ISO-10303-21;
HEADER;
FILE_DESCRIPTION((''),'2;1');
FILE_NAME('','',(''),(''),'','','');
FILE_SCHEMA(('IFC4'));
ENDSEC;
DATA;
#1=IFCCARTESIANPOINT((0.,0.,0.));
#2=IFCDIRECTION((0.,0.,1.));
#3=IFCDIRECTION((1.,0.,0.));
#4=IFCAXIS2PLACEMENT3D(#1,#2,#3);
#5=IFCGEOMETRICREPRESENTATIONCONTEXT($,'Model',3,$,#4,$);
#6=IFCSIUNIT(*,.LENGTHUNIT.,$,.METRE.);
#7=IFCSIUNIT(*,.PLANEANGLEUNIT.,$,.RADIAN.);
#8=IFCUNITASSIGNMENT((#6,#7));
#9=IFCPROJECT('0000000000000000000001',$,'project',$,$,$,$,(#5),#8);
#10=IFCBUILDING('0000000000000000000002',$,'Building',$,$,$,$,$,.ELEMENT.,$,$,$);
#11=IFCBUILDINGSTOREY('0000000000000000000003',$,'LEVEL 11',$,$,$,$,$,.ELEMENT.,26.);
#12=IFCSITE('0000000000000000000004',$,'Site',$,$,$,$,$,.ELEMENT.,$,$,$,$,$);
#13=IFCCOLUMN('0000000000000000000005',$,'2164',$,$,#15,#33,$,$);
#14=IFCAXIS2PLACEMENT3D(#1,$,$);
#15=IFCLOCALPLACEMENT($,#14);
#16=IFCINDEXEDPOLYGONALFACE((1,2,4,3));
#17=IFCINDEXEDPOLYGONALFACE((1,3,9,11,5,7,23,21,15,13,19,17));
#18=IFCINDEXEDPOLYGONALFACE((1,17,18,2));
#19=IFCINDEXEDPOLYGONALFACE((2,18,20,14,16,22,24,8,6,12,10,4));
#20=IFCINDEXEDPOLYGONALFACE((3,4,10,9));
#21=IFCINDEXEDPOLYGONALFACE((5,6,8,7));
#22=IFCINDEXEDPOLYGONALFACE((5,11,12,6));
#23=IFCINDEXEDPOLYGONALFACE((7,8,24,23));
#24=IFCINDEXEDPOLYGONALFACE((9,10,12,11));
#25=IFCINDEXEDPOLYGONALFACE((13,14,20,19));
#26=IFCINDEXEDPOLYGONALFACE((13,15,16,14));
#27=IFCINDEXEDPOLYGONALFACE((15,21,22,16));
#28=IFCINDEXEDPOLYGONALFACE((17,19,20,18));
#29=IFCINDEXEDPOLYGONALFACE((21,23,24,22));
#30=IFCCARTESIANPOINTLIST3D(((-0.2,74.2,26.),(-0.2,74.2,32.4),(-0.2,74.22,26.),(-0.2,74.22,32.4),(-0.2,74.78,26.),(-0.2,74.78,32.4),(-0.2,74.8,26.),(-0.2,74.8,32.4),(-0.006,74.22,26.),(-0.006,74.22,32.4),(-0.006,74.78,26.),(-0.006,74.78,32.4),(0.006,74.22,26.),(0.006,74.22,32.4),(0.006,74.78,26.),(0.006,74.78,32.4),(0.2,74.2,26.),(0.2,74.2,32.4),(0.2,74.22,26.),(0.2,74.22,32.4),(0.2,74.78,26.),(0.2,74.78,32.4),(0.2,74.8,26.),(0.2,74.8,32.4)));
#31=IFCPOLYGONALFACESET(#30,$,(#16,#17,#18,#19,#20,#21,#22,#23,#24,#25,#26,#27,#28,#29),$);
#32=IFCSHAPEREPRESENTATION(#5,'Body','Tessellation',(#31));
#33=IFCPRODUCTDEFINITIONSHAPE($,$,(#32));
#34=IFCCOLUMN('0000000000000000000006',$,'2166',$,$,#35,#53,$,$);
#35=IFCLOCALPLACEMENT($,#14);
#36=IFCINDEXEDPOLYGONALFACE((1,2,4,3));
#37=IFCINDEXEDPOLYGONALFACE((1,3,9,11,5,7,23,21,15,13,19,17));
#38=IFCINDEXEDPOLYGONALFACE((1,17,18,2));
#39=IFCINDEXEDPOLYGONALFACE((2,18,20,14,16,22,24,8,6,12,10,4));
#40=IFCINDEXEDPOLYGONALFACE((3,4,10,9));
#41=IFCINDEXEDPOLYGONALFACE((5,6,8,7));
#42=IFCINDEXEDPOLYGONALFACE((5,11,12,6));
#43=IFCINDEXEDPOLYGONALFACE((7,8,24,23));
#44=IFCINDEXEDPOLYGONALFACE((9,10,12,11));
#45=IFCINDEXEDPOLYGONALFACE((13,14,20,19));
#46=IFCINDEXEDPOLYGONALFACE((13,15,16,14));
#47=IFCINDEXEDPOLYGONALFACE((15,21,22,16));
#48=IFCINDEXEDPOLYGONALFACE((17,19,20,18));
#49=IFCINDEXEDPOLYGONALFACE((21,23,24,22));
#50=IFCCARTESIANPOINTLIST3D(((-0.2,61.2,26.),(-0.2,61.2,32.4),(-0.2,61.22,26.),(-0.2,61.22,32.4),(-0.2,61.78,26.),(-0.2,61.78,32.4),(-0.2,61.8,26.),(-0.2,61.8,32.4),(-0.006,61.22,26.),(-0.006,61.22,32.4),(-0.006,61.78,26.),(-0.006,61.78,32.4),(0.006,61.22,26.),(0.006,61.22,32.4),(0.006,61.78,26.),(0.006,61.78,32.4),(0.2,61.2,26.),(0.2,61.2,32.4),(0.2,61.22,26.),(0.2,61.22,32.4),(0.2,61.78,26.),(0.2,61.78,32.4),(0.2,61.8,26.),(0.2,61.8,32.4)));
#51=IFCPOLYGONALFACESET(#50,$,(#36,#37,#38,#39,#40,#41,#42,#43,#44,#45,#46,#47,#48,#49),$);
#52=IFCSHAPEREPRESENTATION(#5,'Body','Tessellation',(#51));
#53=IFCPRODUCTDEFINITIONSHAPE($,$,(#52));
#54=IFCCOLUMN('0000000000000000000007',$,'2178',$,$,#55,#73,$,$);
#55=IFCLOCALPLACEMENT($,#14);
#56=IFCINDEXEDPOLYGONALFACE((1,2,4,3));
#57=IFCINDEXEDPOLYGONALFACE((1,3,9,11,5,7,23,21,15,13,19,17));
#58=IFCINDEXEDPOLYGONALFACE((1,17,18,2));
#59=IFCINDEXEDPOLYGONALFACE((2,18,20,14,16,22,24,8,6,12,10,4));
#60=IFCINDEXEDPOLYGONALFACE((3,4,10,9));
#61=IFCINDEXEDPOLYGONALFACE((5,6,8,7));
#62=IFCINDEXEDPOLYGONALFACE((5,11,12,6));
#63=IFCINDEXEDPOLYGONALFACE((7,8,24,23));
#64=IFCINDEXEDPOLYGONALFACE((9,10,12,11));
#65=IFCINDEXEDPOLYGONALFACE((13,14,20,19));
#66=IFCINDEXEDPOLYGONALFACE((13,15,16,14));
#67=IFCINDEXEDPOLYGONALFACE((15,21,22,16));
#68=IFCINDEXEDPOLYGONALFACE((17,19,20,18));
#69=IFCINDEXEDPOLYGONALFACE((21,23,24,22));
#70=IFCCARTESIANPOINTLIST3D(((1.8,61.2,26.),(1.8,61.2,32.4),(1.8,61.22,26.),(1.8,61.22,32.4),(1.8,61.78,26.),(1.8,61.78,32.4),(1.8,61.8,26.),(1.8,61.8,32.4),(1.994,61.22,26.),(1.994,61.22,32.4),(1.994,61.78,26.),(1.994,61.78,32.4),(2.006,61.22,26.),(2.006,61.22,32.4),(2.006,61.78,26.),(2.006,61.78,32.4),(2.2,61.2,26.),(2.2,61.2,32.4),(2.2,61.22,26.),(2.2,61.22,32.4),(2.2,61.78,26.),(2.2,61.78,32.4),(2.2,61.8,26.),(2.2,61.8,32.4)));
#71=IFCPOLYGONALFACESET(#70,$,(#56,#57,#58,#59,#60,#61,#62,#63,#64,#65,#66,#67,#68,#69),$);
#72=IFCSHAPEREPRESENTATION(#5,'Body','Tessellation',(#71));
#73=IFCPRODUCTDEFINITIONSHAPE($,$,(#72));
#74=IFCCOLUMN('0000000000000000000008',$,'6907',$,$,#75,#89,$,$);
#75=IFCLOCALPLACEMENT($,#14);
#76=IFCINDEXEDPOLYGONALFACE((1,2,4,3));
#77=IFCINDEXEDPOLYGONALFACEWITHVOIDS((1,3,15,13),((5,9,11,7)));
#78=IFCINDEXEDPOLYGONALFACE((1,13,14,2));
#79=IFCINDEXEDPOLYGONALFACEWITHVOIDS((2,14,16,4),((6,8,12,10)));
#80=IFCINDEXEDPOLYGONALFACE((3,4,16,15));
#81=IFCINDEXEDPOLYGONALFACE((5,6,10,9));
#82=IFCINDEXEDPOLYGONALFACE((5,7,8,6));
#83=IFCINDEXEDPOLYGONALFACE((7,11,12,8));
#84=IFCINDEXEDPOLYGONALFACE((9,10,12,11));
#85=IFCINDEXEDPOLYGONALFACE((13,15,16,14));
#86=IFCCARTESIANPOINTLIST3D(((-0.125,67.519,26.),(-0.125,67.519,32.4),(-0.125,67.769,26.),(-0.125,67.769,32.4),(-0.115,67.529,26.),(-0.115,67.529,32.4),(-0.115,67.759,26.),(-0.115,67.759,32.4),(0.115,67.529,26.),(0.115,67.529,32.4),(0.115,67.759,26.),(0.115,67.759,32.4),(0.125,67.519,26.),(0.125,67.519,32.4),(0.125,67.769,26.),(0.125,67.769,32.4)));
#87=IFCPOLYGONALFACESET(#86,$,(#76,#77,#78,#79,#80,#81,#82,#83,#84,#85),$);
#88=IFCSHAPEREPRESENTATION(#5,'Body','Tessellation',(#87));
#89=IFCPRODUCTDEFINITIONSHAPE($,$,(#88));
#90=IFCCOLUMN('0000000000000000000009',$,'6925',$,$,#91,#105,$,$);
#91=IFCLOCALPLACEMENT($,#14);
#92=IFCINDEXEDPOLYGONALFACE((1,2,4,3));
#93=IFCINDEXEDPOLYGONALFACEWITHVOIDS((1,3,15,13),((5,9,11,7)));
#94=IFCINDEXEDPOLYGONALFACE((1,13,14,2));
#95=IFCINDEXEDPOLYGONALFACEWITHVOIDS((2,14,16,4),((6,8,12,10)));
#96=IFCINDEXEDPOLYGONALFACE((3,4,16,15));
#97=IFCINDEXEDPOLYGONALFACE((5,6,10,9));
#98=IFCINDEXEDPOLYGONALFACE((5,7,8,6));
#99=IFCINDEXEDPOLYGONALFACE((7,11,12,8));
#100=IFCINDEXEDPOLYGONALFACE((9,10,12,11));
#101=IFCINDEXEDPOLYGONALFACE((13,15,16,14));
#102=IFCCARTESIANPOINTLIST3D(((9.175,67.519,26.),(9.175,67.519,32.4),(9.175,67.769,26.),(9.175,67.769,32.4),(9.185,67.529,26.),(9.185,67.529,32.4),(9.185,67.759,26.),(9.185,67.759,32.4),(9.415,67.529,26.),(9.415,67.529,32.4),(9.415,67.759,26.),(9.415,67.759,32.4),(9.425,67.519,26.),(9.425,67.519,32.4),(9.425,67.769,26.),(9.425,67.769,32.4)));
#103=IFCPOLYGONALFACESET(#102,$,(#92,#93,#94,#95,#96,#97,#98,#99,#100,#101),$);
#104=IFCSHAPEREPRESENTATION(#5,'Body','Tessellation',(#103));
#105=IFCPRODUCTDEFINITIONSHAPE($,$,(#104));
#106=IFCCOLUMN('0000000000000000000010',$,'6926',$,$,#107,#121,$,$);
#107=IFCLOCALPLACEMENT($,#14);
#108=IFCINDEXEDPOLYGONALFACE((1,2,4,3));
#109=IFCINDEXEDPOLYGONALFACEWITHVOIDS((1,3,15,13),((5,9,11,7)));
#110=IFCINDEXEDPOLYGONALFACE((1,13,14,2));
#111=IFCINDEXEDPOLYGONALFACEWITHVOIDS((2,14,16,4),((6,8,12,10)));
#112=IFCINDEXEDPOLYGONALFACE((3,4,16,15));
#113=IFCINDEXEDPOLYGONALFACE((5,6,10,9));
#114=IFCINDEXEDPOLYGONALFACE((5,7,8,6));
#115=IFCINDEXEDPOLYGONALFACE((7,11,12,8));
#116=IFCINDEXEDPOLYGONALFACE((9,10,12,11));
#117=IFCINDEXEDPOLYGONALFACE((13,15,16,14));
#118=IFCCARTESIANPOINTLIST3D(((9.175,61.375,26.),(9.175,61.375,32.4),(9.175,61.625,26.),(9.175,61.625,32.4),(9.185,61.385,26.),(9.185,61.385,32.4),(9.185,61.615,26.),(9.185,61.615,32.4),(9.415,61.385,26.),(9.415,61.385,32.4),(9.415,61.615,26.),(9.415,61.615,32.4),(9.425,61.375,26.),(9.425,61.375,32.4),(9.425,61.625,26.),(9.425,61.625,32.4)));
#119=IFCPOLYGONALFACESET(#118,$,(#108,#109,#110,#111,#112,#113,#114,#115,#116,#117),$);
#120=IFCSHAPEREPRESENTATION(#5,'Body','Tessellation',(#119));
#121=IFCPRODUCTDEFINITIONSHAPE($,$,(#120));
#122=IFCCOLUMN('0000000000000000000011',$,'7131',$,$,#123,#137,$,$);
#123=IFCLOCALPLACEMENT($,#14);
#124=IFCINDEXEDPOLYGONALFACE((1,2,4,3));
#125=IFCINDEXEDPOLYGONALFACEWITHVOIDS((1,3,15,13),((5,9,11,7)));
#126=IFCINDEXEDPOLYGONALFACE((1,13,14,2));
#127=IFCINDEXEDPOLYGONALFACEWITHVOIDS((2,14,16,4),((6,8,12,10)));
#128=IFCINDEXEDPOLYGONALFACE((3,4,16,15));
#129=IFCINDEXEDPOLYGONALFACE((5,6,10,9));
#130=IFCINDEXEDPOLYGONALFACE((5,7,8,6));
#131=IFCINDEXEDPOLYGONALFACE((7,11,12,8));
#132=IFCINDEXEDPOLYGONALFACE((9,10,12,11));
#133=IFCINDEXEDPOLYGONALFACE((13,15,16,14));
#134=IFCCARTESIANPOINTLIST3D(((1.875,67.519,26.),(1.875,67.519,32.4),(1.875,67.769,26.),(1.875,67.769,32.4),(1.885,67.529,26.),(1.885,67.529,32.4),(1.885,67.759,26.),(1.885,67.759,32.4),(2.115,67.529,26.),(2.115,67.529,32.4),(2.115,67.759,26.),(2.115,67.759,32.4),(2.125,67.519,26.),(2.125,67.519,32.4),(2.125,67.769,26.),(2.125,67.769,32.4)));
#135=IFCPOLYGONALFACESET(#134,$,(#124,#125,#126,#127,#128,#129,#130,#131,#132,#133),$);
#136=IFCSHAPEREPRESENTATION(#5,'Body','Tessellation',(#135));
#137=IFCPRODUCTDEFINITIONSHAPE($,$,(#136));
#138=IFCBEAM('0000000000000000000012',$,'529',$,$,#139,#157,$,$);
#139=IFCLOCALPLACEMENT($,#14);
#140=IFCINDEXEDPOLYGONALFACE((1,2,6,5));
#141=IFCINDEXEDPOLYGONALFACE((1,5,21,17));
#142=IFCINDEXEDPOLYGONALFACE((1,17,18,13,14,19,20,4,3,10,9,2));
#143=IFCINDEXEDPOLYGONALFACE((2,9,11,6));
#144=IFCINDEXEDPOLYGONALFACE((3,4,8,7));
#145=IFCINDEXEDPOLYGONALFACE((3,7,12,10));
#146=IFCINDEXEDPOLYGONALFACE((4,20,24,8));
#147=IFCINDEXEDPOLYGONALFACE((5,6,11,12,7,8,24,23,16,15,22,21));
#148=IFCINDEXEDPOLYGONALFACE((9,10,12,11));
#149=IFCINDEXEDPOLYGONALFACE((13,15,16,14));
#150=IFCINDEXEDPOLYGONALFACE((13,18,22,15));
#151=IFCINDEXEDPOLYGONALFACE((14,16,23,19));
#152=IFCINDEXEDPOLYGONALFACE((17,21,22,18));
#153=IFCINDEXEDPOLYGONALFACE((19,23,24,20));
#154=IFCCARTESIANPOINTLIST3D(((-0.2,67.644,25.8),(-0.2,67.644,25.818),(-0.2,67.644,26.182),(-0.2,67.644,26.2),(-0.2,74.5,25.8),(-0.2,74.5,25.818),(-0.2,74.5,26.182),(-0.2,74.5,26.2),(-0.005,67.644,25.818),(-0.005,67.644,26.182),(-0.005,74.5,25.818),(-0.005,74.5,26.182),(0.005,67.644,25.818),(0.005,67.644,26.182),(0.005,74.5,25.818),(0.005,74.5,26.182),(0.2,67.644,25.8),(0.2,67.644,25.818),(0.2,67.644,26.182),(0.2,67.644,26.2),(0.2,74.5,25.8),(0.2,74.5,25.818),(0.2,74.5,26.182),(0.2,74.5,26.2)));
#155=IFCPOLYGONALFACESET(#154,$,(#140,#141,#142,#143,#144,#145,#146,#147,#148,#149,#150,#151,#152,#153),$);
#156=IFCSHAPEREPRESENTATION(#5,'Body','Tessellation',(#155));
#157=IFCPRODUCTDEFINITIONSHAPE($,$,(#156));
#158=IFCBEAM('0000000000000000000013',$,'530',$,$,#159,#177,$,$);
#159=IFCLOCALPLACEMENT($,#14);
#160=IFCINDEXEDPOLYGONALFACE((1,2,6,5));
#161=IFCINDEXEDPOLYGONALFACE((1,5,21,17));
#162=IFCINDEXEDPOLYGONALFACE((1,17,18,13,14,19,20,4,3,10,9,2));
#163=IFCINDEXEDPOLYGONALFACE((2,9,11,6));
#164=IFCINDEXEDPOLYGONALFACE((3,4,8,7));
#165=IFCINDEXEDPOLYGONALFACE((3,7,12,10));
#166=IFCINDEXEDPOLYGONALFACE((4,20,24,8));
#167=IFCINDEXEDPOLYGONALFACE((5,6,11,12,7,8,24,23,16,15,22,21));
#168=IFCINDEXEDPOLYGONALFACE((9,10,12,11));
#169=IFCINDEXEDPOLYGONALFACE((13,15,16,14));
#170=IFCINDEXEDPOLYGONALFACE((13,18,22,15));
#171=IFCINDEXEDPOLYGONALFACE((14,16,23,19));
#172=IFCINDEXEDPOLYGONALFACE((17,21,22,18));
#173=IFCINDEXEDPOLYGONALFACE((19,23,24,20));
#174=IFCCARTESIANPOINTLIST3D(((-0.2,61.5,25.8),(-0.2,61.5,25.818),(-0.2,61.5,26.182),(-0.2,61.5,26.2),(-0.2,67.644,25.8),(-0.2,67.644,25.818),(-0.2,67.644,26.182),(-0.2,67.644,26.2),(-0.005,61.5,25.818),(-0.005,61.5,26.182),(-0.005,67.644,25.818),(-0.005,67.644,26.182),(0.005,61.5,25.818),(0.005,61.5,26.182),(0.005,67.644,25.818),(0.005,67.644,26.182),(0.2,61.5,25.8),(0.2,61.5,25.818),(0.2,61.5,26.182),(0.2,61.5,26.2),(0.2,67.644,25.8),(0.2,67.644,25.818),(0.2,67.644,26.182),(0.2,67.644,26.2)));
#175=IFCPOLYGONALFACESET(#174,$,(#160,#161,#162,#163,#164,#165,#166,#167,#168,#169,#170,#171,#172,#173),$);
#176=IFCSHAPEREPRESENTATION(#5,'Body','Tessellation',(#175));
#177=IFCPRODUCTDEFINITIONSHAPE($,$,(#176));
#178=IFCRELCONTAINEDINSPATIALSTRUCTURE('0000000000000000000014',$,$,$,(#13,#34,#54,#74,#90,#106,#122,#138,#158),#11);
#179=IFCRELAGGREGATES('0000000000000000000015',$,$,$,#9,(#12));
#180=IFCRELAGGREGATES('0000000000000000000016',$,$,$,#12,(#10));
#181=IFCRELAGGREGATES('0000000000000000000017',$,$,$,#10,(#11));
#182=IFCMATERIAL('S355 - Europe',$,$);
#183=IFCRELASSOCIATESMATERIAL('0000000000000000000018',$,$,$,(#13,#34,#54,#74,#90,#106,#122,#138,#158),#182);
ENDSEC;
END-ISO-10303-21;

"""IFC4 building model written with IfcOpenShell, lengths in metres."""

from ifc_helpers import new_model, si_unit, frame, origin_with_axes, origin_2d_with_axis, place, context, project, spatial, hollow_rectangle, i_section, extrude, material, material_profile, profile_set, profile_usage, element, save


model = new_model("IFC4")

# Units and contexts
model_context = context("Model", 3, world=origin_with_axes())
ifc_project = project(units=[si_unit("LENGTHUNIT", "METRE"), si_unit("PLANEANGLEUNIT", "RADIAN")], contexts=[model_context])

# Site, building, storey
site = spatial("IfcSite", under=ifc_project, Name="Site", CompositionType="ELEMENT")
building = spatial("IfcBuilding", under=site, Name="Building", CompositionType="ELEMENT")
storey = spatial("IfcBuildingStorey", under=building, Name="LEVEL 11", CompositionType="ELEMENT", Elevation=26.0)

# Columns
ifc_material = material(Name="S355 - Europe")
ifc_material_profile_1 = material_profile(ifc_material, i_section(OverallWidth=0.4, OverallDepth=0.6, WebThickness=0.012, FlangeThickness=0.02, at=origin_2d_with_axis()))
ifc_profile_set_1 = profile_set([ifc_material_profile_1])
ifc_profile_usage_1 = profile_usage(ifc_profile_set_1, cardinal=10)
column_1_placement = place(None, frame((0.0, 74.5, 26.0), z_axis=(0.0, 0.0, 1.0), x_axis=(1.0, 0.0, 0.0)))
element("IfcColumn", 1, at=column_1_placement, inside=storey, material=ifc_profile_usage_1, Name="2164", context=model_context, shape_type="SweptSolid", body=[
    extrude(i_section(OverallWidth=0.4, OverallDepth=0.6, WebThickness=0.012, FlangeThickness=0.02, at=origin_2d_with_axis()), origin_with_axes(), (0.0, 0.0, 1.0), 6.4),
])
ifc_material_profile_2 = material_profile(ifc_material, i_section(OverallWidth=0.4, OverallDepth=0.6, WebThickness=0.012, FlangeThickness=0.02, at=origin_2d_with_axis()))
ifc_profile_set_2 = profile_set([ifc_material_profile_2])
ifc_profile_usage_2 = profile_usage(ifc_profile_set_2, cardinal=10)
column_2_placement = place(None, frame((0.0, 61.5, 26.0), z_axis=(0.0, 0.0, 1.0), x_axis=(1.0, 0.0, 0.0)))
element("IfcColumn", 2, at=column_2_placement, inside=storey, material=ifc_profile_usage_2, Name="2166", context=model_context, shape_type="SweptSolid", body=[
    extrude(i_section(OverallWidth=0.4, OverallDepth=0.6, WebThickness=0.012, FlangeThickness=0.02, at=origin_2d_with_axis()), origin_with_axes(), (0.0, 0.0, 1.0), 6.4),
])
ifc_material_profile_3 = material_profile(ifc_material, i_section(OverallWidth=0.4, OverallDepth=0.6, WebThickness=0.012, FlangeThickness=0.02, at=origin_2d_with_axis()))
ifc_profile_set_3 = profile_set([ifc_material_profile_3])
ifc_profile_usage_3 = profile_usage(ifc_profile_set_3, cardinal=10)
column_3_placement = place(None, frame((2.0, 61.5, 26.0), z_axis=(0.0, 0.0, 1.0), x_axis=(1.0, 0.0, 0.0)))
element("IfcColumn", 3, at=column_3_placement, inside=storey, material=ifc_profile_usage_3, Name="2178", context=model_context, shape_type="SweptSolid", body=[
    extrude(i_section(OverallWidth=0.4, OverallDepth=0.6, WebThickness=0.012, FlangeThickness=0.02, at=origin_2d_with_axis()), origin_with_axes(), (0.0, 0.0, 1.0), 6.4),
])
ifc_material_profile_4 = material_profile(ifc_material, hollow_rectangle(XDim=0.25, YDim=0.25, WallThickness=0.01, at=origin_2d_with_axis()))
ifc_profile_set_4 = profile_set([ifc_material_profile_4])
ifc_profile_usage_4 = profile_usage(ifc_profile_set_4, cardinal=10)
column_4_placement = place(None, frame((0.0, 67.644, 26.0), z_axis=(0.0, 0.0, 1.0), x_axis=(0.0, -1.0, 0.0)))
element("IfcColumn", 4, at=column_4_placement, inside=storey, material=ifc_profile_usage_4, Name="6907", context=model_context, shape_type="SweptSolid", body=[
    extrude(hollow_rectangle(XDim=0.25, YDim=0.25, WallThickness=0.01, at=origin_2d_with_axis()), origin_with_axes(), (0.0, 0.0, 1.0), 6.4),
])
ifc_material_profile_5 = material_profile(ifc_material, hollow_rectangle(XDim=0.25, YDim=0.25, WallThickness=0.01, at=origin_2d_with_axis()))
ifc_profile_set_5 = profile_set([ifc_material_profile_5])
ifc_profile_usage_5 = profile_usage(ifc_profile_set_5, cardinal=10)
column_5_placement = place(None, frame((9.3, 67.644, 26.0), z_axis=(0.0, 0.0, 1.0), x_axis=(0.0, -1.0, 0.0)))
element("IfcColumn", 5, at=column_5_placement, inside=storey, material=ifc_profile_usage_5, Name="6925", context=model_context, shape_type="SweptSolid", body=[
    extrude(hollow_rectangle(XDim=0.25, YDim=0.25, WallThickness=0.01, at=origin_2d_with_axis()), origin_with_axes(), (0.0, 0.0, 1.0), 6.4),
])
ifc_material_profile_6 = material_profile(ifc_material, hollow_rectangle(XDim=0.25, YDim=0.25, WallThickness=0.01, at=origin_2d_with_axis()))
ifc_profile_set_6 = profile_set([ifc_material_profile_6])
ifc_profile_usage_6 = profile_usage(ifc_profile_set_6, cardinal=10)
column_6_placement = place(None, frame((9.3, 61.5, 26.0), z_axis=(0.0, 0.0, 1.0), x_axis=(0.0, -1.0, 0.0)))
element("IfcColumn", 6, at=column_6_placement, inside=storey, material=ifc_profile_usage_6, Name="6926", context=model_context, shape_type="SweptSolid", body=[
    extrude(hollow_rectangle(XDim=0.25, YDim=0.25, WallThickness=0.01, at=origin_2d_with_axis()), origin_with_axes(), (0.0, 0.0, 1.0), 6.4),
])
ifc_material_profile_7 = material_profile(ifc_material, hollow_rectangle(XDim=0.25, YDim=0.25, WallThickness=0.01, at=origin_2d_with_axis()))
ifc_profile_set_7 = profile_set([ifc_material_profile_7])
ifc_profile_usage_7 = profile_usage(ifc_profile_set_7, cardinal=10)
column_7_placement = place(None, frame((2.0, 67.644, 26.0), z_axis=(0.0, 0.0, 1.0), x_axis=(0.0, -1.0, 0.0)))
element("IfcColumn", 7, at=column_7_placement, inside=storey, material=ifc_profile_usage_7, Name="7131", context=model_context, shape_type="SweptSolid", body=[
    extrude(hollow_rectangle(XDim=0.25, YDim=0.25, WallThickness=0.01, at=origin_2d_with_axis()), origin_with_axes(), (0.0, 0.0, 1.0), 6.4),
])

# Beams
ifc_material_profile_8 = material_profile(ifc_material, i_section(OverallWidth=0.4, OverallDepth=0.4, WebThickness=0.01, FlangeThickness=0.018, at=origin_2d_with_axis()))
ifc_profile_set_8 = profile_set([ifc_material_profile_8])
ifc_profile_usage_8 = profile_usage(ifc_profile_set_8, cardinal=10)
beam_1_placement = place(None, frame((0.0, 74.5, 26.0), z_axis=(0.0, -1.0, 0.0), x_axis=(1.0, 0.0, 0.0)))
element("IfcBeam", 8, at=beam_1_placement, inside=storey, material=ifc_profile_usage_8, Name="529", context=model_context, shape_type="SweptSolid", body=[
    extrude(i_section(OverallWidth=0.4, OverallDepth=0.4, WebThickness=0.01, FlangeThickness=0.018, at=origin_2d_with_axis()), origin_with_axes(), (0.0, 0.0, 1.0), 6.856),
])
ifc_material_profile_9 = material_profile(ifc_material, i_section(OverallWidth=0.4, OverallDepth=0.4, WebThickness=0.01, FlangeThickness=0.018, at=origin_2d_with_axis()))
ifc_profile_set_9 = profile_set([ifc_material_profile_9])
ifc_profile_usage_9 = profile_usage(ifc_profile_set_9, cardinal=10)
beam_2_placement = place(None, frame((0.0, 67.644, 26.0), z_axis=(0.0, -1.0, 0.0), x_axis=(1.0, 0.0, 0.0)))
element("IfcBeam", 9, at=beam_2_placement, inside=storey, material=ifc_profile_usage_9, Name="530", context=model_context, shape_type="SweptSolid", body=[
    extrude(i_section(OverallWidth=0.4, OverallDepth=0.4, WebThickness=0.01, FlangeThickness=0.018, at=origin_2d_with_axis()), origin_with_axes(), (0.0, 0.0, 1.0), 6.144),
])

save(model, "model.ifc")
